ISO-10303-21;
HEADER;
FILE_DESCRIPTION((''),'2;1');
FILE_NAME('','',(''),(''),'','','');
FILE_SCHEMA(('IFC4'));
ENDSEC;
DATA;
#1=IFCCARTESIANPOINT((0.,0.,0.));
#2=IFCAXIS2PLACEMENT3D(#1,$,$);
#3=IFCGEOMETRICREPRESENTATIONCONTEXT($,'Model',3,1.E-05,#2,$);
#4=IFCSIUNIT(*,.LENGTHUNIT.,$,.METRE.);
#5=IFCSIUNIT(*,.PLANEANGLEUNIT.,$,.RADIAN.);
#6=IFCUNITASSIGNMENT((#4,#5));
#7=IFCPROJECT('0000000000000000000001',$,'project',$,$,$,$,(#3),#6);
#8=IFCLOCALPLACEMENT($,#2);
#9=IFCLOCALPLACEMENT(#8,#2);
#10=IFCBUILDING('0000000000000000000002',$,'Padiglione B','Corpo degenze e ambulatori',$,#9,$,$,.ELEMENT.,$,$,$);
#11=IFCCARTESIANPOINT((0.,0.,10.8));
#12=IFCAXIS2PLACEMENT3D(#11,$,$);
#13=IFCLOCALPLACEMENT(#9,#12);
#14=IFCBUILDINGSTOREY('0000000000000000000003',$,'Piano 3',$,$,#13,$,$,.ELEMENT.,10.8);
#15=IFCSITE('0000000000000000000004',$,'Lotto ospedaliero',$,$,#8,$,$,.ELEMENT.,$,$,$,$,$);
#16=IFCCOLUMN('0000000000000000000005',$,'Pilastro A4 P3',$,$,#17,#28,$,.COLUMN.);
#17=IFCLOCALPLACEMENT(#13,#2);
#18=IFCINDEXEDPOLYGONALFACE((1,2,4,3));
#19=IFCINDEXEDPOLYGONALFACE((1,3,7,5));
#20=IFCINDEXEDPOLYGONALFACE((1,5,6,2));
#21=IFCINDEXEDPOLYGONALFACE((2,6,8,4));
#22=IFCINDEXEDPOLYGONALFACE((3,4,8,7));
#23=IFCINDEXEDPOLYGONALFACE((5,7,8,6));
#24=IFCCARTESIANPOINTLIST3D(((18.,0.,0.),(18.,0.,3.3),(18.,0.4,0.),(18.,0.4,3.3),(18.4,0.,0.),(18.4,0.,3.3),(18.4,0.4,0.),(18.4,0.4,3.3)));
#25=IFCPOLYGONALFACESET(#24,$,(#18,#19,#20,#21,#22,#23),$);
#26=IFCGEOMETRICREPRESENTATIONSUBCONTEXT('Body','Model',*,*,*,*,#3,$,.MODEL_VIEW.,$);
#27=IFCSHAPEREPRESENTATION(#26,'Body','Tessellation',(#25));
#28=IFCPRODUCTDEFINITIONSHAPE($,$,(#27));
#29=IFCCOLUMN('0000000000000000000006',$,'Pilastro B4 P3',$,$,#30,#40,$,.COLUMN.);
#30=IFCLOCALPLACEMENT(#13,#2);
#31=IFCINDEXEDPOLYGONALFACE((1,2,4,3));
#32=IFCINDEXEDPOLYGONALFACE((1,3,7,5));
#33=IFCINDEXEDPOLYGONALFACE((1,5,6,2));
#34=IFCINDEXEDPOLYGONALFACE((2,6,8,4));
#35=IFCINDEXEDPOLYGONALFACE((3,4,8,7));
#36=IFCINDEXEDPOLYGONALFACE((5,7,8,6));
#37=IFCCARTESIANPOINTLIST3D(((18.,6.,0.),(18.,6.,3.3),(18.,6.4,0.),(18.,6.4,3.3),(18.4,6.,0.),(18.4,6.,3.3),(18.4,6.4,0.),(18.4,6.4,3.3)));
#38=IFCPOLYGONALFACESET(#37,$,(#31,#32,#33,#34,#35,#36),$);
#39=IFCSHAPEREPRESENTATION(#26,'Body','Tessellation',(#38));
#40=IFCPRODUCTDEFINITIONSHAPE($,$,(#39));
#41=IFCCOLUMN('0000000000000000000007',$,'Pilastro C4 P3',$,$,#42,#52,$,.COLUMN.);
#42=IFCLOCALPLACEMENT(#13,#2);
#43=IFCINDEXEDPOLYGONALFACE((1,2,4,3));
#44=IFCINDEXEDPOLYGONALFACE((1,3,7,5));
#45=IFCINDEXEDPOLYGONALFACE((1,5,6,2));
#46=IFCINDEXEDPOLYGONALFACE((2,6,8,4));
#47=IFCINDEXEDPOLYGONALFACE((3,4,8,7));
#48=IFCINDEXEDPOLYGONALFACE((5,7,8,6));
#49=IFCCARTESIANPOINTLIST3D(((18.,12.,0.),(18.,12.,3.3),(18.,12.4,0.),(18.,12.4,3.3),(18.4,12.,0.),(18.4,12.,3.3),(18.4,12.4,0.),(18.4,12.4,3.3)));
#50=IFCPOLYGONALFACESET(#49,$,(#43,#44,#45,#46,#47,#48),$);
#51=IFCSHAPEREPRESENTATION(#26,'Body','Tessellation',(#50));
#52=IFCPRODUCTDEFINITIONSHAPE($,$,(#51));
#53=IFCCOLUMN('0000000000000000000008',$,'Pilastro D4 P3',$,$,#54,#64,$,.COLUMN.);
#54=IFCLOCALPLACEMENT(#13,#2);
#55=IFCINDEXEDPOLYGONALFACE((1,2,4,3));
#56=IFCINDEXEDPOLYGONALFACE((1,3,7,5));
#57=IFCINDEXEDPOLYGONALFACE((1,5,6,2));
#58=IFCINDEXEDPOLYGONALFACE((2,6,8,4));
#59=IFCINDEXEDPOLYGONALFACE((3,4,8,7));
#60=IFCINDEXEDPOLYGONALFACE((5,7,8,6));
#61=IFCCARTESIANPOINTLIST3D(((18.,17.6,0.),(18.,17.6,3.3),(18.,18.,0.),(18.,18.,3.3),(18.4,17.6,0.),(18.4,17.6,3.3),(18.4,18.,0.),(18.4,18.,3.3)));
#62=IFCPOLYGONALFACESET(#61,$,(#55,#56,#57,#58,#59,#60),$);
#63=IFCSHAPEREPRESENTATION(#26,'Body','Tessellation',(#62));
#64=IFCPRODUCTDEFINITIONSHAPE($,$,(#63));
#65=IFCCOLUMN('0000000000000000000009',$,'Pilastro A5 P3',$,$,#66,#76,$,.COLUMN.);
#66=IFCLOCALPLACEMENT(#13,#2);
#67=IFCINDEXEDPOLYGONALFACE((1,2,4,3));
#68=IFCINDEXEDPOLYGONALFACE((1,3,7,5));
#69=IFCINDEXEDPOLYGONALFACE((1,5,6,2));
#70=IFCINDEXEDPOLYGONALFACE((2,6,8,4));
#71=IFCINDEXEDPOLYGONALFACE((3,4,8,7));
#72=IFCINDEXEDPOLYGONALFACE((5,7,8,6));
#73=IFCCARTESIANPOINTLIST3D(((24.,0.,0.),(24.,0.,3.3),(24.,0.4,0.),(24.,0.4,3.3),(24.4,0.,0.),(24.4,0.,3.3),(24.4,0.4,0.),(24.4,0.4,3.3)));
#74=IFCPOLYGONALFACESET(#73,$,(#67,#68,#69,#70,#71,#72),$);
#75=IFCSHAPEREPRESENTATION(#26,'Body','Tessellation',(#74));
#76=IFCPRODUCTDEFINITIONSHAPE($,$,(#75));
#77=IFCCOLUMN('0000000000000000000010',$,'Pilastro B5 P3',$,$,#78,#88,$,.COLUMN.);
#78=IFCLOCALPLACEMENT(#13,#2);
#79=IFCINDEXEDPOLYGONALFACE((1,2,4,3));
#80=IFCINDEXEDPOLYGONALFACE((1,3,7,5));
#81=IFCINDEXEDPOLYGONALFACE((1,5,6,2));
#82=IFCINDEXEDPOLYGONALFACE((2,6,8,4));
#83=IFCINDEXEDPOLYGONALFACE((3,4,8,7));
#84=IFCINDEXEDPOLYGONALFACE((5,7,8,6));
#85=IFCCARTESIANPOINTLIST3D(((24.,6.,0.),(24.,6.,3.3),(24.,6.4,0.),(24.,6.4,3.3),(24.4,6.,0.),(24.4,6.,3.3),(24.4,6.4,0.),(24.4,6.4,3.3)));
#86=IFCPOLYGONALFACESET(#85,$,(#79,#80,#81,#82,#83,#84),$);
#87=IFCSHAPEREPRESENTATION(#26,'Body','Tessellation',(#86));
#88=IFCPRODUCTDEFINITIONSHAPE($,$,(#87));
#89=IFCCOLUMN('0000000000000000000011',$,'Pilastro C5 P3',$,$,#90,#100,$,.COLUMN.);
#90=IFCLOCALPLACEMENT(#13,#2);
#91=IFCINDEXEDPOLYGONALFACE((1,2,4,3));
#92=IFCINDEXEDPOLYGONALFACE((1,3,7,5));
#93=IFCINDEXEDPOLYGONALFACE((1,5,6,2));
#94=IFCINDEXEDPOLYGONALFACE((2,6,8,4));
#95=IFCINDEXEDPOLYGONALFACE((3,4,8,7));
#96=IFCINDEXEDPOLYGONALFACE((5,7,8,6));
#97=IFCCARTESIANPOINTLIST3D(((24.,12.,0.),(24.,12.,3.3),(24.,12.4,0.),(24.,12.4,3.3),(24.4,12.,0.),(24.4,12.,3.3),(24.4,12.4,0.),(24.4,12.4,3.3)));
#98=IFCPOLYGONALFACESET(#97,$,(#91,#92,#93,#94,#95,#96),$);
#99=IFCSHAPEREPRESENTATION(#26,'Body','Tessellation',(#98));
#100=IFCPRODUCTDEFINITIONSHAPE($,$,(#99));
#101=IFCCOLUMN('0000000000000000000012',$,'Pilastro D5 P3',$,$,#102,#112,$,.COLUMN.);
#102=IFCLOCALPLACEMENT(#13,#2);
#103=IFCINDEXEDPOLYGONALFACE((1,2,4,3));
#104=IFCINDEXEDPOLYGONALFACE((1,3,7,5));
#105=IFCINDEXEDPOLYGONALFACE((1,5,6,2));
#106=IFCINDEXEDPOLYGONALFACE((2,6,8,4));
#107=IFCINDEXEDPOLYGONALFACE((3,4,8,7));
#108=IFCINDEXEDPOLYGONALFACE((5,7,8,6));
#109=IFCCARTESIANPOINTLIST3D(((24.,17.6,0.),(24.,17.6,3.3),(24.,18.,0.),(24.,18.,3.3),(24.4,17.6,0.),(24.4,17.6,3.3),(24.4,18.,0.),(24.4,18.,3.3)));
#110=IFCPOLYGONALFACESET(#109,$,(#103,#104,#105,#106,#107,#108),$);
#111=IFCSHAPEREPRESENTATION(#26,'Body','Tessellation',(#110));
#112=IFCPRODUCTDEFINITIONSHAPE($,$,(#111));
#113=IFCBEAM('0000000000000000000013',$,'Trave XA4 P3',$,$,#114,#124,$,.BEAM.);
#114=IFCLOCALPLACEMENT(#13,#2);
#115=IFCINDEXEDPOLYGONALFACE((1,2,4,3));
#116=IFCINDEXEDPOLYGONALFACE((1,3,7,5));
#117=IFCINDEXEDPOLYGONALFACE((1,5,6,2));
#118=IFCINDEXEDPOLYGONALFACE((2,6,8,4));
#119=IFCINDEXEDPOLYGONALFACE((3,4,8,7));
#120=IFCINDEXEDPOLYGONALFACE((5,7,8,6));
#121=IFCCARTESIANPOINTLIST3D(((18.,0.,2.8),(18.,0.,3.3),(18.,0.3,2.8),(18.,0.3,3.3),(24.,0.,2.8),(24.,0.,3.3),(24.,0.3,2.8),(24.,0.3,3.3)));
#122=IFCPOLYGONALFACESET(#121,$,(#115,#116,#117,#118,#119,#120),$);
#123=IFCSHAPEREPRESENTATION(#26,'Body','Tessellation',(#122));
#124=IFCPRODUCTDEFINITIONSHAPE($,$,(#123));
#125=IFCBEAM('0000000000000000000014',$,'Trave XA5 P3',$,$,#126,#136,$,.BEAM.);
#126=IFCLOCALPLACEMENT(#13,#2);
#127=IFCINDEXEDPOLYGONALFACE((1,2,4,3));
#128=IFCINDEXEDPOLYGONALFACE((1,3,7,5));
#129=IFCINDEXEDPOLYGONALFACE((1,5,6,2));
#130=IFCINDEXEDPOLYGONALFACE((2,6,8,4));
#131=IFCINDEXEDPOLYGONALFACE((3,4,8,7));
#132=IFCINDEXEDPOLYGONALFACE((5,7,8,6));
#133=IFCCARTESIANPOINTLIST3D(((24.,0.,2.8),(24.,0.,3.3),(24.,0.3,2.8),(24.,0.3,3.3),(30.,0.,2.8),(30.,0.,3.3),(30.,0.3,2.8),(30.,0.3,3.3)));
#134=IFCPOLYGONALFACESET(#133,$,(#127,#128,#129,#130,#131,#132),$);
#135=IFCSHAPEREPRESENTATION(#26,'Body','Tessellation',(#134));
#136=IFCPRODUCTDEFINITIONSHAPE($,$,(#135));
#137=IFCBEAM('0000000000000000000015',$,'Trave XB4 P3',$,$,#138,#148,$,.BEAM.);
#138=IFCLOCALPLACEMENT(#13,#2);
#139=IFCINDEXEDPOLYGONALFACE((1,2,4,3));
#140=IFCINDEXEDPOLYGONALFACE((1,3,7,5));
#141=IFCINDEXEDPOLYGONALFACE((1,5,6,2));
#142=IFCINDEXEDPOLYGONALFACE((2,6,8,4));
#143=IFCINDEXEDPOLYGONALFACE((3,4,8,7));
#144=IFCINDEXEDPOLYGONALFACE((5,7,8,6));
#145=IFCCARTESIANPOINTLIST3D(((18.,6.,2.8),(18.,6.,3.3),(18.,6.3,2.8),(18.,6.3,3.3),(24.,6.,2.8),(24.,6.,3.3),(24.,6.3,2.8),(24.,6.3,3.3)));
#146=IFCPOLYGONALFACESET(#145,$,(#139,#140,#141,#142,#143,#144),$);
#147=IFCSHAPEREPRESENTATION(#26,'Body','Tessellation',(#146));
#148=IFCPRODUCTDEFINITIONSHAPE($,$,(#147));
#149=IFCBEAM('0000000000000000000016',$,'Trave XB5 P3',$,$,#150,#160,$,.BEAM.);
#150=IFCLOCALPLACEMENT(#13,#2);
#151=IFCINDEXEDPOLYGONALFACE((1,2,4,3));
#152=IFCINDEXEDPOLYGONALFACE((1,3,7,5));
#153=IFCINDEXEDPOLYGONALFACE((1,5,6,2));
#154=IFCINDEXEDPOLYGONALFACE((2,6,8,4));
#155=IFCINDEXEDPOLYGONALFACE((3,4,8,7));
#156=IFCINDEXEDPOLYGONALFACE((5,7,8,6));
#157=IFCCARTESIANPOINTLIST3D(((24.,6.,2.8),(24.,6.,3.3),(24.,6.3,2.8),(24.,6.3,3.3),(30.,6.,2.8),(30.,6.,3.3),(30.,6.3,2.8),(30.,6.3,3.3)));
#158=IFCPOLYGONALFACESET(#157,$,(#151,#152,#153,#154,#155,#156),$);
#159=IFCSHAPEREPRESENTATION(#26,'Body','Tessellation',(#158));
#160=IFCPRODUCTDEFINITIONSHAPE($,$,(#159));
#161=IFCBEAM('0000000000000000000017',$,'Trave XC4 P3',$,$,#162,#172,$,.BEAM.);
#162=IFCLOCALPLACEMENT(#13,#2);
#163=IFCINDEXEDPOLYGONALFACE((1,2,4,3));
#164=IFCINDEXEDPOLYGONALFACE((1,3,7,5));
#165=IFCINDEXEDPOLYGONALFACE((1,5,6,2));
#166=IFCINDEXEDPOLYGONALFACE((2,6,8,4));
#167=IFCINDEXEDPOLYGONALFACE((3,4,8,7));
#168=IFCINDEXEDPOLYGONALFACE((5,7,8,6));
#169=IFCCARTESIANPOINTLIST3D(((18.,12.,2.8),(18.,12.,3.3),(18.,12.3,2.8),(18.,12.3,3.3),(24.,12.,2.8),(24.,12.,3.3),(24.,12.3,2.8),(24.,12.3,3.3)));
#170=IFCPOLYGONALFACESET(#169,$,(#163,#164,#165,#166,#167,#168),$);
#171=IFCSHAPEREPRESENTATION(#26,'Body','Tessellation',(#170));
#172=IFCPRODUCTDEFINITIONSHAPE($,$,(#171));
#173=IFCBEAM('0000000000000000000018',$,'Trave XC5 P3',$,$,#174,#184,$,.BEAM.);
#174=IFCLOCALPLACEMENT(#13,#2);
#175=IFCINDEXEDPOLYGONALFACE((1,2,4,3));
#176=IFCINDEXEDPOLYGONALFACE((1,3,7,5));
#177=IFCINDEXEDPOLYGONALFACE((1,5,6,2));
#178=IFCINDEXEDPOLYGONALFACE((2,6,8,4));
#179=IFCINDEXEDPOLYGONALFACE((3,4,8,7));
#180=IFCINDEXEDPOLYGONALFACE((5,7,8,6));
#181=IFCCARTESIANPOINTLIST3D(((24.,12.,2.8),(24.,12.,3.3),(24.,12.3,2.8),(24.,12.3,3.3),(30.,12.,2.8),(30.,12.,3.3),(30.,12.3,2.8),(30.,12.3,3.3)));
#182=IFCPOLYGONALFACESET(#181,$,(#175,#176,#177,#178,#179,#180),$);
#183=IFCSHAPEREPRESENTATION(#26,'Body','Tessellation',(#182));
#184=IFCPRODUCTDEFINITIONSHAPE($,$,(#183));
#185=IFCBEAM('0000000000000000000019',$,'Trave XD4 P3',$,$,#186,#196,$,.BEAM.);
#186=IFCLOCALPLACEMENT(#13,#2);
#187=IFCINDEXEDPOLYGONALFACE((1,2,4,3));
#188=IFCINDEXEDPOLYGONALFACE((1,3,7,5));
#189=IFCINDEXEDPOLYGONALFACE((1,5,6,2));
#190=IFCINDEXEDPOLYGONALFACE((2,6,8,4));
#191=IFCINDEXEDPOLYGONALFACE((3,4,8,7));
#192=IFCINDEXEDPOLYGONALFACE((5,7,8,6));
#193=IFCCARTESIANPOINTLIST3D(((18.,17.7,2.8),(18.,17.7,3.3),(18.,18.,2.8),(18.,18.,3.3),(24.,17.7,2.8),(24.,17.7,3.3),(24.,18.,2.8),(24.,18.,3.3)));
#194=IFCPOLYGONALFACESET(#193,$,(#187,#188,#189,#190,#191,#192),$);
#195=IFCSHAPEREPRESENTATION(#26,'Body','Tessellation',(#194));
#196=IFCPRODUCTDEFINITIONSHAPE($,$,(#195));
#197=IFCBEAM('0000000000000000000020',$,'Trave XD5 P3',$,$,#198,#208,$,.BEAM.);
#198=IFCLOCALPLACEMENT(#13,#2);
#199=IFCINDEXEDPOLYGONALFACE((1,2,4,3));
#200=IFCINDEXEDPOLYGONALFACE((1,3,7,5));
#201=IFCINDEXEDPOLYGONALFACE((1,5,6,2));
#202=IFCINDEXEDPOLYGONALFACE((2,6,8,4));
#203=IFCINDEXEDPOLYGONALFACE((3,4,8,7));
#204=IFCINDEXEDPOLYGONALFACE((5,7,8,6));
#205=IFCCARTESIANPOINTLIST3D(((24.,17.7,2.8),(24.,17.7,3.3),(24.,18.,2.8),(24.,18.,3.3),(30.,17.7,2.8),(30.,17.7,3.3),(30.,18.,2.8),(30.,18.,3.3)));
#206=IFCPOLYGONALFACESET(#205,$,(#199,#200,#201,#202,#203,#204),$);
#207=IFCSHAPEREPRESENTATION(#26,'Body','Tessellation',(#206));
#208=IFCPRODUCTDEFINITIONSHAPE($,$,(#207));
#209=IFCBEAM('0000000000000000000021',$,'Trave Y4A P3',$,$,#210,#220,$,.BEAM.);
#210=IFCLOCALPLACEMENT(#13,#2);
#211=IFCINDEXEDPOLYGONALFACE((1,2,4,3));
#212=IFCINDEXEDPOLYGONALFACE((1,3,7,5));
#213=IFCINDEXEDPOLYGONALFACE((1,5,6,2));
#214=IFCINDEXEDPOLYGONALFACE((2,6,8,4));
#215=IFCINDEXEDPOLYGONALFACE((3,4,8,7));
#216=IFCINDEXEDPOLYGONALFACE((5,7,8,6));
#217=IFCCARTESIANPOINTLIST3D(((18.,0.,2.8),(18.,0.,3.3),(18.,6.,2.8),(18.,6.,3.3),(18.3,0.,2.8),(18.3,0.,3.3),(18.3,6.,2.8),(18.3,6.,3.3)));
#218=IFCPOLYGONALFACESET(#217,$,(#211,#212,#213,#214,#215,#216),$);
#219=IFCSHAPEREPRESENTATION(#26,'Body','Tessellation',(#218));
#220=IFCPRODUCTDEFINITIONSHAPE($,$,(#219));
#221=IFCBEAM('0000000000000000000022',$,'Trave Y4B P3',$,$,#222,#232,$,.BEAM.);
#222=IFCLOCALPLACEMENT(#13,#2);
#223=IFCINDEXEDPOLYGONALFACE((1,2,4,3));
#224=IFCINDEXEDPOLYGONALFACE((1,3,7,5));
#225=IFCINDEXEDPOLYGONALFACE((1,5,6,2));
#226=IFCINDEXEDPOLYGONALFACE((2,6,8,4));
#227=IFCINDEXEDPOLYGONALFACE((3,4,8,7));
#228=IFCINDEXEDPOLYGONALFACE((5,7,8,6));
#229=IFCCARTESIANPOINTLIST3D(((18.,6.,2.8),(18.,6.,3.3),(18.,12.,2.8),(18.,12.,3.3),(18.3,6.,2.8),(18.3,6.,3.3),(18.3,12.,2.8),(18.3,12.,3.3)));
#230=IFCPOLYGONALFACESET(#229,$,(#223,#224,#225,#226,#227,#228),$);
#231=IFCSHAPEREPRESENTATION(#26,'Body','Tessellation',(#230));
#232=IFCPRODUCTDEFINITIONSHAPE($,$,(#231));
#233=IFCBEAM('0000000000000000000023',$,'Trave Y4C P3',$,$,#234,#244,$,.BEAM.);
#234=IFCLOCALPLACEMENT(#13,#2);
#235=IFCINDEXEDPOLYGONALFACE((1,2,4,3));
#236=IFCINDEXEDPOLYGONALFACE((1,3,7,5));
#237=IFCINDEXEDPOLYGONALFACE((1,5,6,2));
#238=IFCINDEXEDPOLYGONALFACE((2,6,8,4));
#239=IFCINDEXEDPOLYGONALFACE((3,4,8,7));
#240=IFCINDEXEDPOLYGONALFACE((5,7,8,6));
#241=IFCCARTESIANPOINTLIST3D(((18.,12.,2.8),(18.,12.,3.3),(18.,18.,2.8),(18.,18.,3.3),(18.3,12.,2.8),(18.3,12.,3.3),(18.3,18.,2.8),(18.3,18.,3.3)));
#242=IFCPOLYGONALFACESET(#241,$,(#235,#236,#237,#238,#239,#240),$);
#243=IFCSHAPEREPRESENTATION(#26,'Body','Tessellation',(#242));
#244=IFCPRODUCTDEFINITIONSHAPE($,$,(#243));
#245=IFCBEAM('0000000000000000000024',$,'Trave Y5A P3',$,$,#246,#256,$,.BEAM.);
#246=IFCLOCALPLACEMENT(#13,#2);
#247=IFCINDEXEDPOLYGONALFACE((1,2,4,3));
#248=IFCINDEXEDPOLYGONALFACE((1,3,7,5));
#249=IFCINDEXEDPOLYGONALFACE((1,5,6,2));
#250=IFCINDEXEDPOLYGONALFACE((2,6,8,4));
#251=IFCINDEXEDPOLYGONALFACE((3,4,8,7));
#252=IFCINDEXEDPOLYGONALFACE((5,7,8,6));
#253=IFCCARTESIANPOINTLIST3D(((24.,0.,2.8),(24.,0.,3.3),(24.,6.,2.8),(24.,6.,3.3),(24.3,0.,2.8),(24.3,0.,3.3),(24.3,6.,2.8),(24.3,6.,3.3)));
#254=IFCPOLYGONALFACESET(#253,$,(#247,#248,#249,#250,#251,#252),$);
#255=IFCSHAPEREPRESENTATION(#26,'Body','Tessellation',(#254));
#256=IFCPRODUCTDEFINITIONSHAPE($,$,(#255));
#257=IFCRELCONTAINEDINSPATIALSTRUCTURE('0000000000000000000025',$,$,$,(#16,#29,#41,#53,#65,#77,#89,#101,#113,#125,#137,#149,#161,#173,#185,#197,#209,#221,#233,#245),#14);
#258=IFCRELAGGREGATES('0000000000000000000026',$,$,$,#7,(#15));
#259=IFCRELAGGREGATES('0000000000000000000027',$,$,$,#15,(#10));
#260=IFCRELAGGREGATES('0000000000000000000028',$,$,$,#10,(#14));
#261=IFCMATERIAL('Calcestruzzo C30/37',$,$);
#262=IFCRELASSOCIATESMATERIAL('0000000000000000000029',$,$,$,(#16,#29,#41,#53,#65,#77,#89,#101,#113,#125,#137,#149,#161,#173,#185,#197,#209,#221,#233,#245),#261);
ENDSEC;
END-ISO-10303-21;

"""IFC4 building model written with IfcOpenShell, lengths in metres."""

from ifc_helpers import new_model, si_unit, frame, frame_2d, origin, place, context, subcontext, project, spatial, rectangle, extrude, material, element, save


model = new_model("IFC4")

# Units and contexts
model_context = context("Model", 3, precision=1e-05, world=origin())
body_context = subcontext(model_context, "Body", "Model", "MODEL_VIEW")
ifc_project = project(units=[si_unit("LENGTHUNIT", "METRE"), si_unit("PLANEANGLEUNIT", "RADIAN")], contexts=[model_context])

# Site, building, storey
site_placement = place(None, origin())
site = spatial("IfcSite", under=ifc_project, at=site_placement, Name="Lotto ospedaliero", CompositionType="ELEMENT")
building_placement = place(site_placement, origin())
building = spatial("IfcBuilding", under=site, at=building_placement, Name="Padiglione B", Description="Corpo degenze e ambulatori", CompositionType="ELEMENT")
storey_placement = place(building_placement, frame((0.0, 0.0, 10.8)))
storey = spatial("IfcBuildingStorey", under=building, at=storey_placement, Name="Piano 3", CompositionType="ELEMENT", Elevation=10.8)

# Columns
ifc_material_1 = material(Name="Calcestruzzo C30/37")
for number, where, name in (
    (1, (18.0, 0.0, 0.0), "Pilastro A4 P3"),
    (2, (18.0, 6.0, 0.0), "Pilastro B4 P3"),
    (3, (18.0, 12.0, 0.0), "Pilastro C4 P3"),
    (4, (18.0, 17.6, 0.0), "Pilastro D4 P3"),
    (5, (24.0, 0.0, 0.0), "Pilastro A5 P3"),
    (6, (24.0, 6.0, 0.0), "Pilastro B5 P3"),
    (7, (24.0, 12.0, 0.0), "Pilastro C5 P3"),
    (8, (24.0, 17.6, 0.0), "Pilastro D5 P3"),
):
    element("IfcColumn", number, at=place(storey_placement, frame(where)), inside=storey, material=ifc_material_1, Name=name, PredefinedType="COLUMN", context=body_context, shape_type="SweptSolid", body=[
        extrude(rectangle(XDim=0.4, YDim=0.4, at=frame_2d((0.2, 0.2))), origin(), (0.0, 0.0, 1.0), 3.3),
    ])

# Beams
for number, where, name in (
    (9, (18.0, 0.0, 2.8), "Trave XA4 P3"),
    (10, (24.0, 0.0, 2.8), "Trave XA5 P3"),
    (11, (18.0, 6.0, 2.8), "Trave XB4 P3"),
    (12, (24.0, 6.0, 2.8), "Trave XB5 P3"),
    (13, (18.0, 12.0, 2.8), "Trave XC4 P3"),
    (14, (24.0, 12.0, 2.8), "Trave XC5 P3"),
    (15, (18.0, 17.7, 2.8), "Trave XD4 P3"),
    (16, (24.0, 17.7, 2.8), "Trave XD5 P3"),
):
    element("IfcBeam", number, at=place(storey_placement, frame(where)), inside=storey, material=ifc_material_1, Name=name, PredefinedType="BEAM", context=body_context, shape_type="SweptSolid", body=[
        extrude(rectangle(XDim=6.0, YDim=0.3, at=frame_2d((3.0, 0.15))), origin(), (0.0, 0.0, 1.0), 0.5),
    ])
for number, where, name in (
    (17, (18.0, 0.0, 2.8), "Trave Y4A P3"),
    (18, (18.0, 6.0, 2.8), "Trave Y4B P3"),
    (19, (18.0, 12.0, 2.8), "Trave Y4C P3"),
    (20, (24.0, 0.0, 2.8), "Trave Y5A P3"),
):
    element("IfcBeam", number, at=place(storey_placement, frame(where)), inside=storey, material=ifc_material_1, Name=name, PredefinedType="BEAM", context=body_context, shape_type="SweptSolid", body=[
        extrude(rectangle(XDim=0.3, YDim=6.0, at=frame_2d((0.15, 3.0))), origin(), (0.0, 0.0, 1.0), 0.5),
    ])

save(model, "model.ifc")
